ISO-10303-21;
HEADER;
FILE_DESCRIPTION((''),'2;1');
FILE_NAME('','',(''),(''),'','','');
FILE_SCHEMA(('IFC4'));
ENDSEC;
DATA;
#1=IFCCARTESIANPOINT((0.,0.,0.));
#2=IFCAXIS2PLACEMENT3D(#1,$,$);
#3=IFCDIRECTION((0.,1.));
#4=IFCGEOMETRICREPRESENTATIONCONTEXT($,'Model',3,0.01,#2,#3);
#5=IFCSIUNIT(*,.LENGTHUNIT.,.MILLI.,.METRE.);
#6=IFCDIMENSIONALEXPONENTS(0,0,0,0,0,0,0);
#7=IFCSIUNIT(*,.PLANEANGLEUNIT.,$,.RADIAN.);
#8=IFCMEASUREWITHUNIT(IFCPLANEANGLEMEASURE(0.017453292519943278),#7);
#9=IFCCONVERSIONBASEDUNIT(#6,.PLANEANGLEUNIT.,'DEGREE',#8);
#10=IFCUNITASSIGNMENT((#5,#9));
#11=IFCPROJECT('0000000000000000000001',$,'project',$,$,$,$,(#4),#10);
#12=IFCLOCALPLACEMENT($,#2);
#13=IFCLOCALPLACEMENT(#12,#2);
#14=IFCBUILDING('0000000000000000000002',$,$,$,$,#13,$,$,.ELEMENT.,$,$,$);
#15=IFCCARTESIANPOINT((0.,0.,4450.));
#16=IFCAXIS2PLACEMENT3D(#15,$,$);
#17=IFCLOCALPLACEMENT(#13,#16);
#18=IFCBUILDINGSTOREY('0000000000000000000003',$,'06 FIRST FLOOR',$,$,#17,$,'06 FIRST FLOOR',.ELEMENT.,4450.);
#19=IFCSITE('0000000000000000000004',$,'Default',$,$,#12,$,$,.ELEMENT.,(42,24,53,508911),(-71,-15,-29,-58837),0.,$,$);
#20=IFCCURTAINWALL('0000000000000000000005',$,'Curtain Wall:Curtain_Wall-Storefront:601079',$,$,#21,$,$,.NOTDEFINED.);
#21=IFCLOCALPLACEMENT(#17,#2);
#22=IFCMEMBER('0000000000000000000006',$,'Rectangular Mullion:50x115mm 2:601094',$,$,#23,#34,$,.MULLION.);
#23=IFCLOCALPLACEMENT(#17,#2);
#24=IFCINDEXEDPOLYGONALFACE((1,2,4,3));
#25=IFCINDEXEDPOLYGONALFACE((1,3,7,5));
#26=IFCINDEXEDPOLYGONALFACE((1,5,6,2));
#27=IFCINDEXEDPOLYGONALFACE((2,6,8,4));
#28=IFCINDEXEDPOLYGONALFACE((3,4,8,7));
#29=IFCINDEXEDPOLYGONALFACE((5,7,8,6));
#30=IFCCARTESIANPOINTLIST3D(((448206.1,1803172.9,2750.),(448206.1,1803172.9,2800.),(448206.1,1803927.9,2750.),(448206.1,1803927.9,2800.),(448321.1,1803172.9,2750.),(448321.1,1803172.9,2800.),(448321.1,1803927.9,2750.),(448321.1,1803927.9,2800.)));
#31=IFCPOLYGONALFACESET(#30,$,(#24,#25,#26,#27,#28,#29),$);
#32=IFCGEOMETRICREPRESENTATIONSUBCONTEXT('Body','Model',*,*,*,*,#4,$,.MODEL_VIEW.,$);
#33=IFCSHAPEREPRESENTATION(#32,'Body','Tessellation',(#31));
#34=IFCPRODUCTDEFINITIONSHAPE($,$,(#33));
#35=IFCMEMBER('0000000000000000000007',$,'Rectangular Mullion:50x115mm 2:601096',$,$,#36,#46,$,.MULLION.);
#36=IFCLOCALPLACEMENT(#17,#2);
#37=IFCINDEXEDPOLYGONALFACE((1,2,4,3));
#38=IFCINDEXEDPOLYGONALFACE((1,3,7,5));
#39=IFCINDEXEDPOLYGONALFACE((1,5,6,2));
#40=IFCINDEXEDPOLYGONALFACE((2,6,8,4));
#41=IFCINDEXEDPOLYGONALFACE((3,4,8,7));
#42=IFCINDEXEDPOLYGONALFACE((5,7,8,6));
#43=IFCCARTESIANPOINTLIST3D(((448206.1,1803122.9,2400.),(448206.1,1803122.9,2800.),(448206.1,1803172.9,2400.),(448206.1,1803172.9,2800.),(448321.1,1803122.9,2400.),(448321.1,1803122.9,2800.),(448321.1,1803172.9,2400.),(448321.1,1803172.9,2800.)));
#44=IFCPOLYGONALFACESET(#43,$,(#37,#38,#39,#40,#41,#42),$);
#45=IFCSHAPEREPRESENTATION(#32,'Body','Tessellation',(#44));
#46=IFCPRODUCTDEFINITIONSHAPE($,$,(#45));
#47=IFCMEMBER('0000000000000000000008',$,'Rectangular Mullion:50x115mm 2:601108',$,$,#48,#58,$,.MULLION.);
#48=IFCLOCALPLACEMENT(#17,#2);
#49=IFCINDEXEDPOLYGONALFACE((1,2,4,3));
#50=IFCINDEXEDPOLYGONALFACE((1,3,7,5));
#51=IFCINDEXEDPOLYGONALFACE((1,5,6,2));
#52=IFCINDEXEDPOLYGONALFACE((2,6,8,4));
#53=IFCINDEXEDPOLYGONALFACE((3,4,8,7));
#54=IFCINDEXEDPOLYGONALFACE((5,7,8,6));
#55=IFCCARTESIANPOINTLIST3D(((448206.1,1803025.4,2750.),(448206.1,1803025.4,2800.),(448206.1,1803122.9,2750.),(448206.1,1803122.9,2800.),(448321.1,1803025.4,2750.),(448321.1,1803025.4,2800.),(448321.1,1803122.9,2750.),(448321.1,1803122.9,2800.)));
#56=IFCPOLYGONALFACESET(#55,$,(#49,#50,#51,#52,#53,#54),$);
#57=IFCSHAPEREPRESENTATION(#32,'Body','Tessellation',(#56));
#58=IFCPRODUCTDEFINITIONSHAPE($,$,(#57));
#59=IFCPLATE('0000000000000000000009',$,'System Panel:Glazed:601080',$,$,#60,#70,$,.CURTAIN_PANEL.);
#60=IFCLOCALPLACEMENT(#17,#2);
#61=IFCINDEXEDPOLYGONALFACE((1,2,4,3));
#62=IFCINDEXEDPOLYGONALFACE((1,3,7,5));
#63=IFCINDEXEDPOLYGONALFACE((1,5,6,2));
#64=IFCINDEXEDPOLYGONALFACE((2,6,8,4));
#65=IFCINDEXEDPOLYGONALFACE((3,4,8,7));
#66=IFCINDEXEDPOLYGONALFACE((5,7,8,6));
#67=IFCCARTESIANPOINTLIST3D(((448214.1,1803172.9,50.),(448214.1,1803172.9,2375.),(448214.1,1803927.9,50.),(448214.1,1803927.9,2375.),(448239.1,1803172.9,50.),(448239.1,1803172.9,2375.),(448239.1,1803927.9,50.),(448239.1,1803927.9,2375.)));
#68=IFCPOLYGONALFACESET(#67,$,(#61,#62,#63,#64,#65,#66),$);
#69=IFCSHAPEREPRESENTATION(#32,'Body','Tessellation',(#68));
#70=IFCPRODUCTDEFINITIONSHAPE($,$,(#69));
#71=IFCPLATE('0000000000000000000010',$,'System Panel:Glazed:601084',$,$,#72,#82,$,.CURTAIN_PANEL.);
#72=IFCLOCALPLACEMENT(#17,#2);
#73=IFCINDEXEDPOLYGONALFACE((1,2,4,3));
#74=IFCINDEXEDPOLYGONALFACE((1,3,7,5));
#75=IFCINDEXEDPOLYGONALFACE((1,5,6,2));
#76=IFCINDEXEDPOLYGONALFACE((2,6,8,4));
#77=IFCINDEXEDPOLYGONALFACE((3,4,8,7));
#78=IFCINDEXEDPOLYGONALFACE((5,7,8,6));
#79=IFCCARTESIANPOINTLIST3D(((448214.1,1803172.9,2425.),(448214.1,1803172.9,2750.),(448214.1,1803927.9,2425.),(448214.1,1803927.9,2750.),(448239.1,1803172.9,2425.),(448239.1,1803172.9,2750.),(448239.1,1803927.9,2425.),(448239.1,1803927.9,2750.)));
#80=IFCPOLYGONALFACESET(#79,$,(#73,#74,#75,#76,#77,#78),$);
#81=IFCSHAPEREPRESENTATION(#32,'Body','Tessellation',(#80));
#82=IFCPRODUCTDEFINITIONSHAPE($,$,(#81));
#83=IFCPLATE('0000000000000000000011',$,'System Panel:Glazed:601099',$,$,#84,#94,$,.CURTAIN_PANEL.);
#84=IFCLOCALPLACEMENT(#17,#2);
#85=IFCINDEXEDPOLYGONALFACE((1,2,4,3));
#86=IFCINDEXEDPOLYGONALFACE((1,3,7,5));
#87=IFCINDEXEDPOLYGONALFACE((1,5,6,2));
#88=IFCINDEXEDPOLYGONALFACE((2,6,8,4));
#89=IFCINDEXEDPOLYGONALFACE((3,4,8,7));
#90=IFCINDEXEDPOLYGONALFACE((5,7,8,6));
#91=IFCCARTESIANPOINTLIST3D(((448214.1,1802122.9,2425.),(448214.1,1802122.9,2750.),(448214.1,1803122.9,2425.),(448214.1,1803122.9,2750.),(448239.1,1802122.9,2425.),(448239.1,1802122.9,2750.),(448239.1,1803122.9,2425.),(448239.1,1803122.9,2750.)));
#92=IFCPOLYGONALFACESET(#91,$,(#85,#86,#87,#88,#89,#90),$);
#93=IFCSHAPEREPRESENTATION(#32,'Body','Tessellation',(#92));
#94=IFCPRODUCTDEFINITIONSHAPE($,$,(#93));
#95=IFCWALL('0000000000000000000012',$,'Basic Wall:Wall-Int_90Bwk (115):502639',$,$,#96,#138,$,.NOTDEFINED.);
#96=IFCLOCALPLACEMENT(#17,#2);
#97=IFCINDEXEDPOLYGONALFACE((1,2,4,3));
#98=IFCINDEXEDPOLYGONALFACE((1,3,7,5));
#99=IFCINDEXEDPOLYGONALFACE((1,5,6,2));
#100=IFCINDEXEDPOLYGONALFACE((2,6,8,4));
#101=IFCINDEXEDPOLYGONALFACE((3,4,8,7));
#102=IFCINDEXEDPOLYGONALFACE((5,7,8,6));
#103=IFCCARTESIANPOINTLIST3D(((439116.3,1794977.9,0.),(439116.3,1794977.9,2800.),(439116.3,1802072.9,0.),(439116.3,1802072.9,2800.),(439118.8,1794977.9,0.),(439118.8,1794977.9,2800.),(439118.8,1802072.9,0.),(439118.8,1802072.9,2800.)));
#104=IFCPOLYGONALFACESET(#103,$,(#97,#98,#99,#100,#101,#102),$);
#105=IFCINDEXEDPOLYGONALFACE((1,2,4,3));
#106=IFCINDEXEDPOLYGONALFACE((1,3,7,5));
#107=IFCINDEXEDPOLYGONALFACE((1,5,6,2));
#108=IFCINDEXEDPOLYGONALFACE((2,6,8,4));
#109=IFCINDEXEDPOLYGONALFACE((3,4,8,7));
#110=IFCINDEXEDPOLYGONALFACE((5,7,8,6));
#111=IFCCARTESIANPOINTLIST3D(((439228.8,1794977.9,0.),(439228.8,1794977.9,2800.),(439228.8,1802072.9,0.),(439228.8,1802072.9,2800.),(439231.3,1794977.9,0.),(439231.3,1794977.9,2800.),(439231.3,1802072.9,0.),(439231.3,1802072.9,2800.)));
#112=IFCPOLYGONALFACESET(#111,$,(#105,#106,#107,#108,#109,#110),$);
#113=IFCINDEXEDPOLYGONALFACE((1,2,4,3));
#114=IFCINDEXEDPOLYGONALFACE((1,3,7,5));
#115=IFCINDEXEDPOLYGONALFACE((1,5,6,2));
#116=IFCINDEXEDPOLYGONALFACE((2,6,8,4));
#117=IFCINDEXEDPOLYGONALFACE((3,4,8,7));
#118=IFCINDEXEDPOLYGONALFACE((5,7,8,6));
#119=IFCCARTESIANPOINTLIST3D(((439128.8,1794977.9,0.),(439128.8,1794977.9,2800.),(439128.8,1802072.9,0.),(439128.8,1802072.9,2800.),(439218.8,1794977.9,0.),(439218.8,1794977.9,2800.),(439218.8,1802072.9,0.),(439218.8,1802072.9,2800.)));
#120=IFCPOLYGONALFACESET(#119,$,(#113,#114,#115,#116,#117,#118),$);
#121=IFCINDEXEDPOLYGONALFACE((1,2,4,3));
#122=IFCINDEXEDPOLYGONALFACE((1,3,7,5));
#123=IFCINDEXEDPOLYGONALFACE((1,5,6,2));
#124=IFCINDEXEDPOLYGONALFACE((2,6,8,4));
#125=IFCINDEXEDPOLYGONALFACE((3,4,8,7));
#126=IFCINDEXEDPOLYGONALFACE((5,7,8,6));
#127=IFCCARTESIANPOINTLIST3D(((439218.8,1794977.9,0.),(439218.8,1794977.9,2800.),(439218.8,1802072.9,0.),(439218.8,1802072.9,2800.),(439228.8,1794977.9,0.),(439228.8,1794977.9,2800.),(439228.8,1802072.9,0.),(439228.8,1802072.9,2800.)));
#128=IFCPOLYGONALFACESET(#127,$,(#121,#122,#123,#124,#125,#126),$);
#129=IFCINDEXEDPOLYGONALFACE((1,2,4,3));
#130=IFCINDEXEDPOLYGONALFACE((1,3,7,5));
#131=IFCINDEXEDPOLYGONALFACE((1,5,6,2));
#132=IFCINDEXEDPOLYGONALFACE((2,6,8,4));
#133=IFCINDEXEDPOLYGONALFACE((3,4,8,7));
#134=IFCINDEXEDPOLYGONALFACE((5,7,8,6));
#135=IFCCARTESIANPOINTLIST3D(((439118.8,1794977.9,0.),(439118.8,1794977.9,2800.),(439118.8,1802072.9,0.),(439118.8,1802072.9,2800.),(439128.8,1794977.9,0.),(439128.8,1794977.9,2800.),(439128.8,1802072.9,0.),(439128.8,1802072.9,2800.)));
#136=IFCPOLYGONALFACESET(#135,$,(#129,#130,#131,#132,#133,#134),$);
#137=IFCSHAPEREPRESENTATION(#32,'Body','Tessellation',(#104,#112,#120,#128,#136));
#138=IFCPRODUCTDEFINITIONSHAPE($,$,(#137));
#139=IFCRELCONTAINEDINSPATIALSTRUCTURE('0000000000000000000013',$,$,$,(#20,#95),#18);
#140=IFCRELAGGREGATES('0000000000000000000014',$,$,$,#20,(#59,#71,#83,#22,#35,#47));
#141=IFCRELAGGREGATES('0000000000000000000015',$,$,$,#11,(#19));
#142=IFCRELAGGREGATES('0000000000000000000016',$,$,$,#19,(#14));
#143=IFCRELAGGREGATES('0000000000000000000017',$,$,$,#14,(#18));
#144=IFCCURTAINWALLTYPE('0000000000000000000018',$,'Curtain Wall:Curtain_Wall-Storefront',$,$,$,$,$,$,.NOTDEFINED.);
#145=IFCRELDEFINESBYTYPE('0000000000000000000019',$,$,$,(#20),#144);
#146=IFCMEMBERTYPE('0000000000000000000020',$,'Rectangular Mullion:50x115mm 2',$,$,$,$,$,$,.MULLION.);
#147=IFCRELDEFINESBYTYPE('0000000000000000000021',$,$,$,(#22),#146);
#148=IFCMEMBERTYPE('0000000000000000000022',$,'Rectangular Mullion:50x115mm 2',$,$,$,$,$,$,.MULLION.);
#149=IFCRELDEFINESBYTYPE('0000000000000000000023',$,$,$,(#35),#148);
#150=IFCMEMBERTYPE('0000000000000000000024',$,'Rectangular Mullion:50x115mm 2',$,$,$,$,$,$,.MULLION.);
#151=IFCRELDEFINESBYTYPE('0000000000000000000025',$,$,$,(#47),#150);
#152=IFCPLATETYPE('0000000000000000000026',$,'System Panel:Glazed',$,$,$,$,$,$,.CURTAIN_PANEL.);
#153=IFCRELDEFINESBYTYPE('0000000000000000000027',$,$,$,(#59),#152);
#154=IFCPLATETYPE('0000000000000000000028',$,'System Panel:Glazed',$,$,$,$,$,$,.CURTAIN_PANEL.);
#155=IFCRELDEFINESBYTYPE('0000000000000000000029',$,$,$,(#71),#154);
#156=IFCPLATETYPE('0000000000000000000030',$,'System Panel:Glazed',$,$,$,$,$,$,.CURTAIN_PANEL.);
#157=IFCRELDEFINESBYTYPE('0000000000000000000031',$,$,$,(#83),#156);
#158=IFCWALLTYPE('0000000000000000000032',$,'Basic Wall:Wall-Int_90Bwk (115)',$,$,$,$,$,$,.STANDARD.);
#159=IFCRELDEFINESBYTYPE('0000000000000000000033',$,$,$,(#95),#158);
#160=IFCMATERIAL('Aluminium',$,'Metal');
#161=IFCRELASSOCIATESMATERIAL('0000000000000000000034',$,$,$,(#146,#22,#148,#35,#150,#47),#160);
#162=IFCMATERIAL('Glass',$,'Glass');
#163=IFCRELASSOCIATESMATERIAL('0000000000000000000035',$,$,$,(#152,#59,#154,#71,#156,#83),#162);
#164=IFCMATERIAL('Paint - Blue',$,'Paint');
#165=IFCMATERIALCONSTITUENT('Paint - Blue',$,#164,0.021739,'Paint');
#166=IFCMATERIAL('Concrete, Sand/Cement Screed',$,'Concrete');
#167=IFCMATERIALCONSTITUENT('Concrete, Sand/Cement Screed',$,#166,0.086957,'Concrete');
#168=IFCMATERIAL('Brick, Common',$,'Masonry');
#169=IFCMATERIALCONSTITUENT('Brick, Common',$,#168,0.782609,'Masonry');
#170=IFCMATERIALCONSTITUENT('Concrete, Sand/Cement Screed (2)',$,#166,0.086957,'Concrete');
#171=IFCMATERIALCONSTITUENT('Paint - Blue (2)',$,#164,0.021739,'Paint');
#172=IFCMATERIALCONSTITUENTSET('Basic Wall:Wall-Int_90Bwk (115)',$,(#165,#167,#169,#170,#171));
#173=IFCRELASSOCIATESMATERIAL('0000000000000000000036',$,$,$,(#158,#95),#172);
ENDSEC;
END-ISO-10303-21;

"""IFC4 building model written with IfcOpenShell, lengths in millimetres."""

from ifc_helpers import new_model, entity, si_unit, converted_unit, direction, frame, origin, place, context, subcontext, project, spatial, indexed_curve, outline, extrude, source, transform, mapped, material, constituent, constituent_set, type_object, type_shapes, element, aggregate, save


model = new_model("IFC4")

# Units and contexts
model_context = context("Model", 3, precision=0.01, world=origin(), true_north=direction((0.0, 1.0)))
body_context = subcontext(model_context, "Body", "Model", "MODEL_VIEW")
ifc_project = project(units=[si_unit("LENGTHUNIT", "METRE", prefix="MILLI"), converted_unit("PLANEANGLEUNIT", "DEGREE", entity("IfcPlaneAngleMeasure", 0.017453292519943278), si_unit("PLANEANGLEUNIT", "RADIAN"), dimensions=[0, 0, 0, 0, 0, 0, 0])], contexts=[model_context])

# Site, building, storey
site_placement = place(None, origin())
site = spatial("IfcSite", under=ifc_project, at=site_placement, Name="Default", CompositionType="ELEMENT", RefLatitude=(42, 24, 53, 508911), RefLongitude=(-71, -15, -29, -58837), RefElevation=0.0)
building_placement = place(site_placement, origin())
building = spatial("IfcBuilding", under=site, at=building_placement, CompositionType="ELEMENT")
storey_placement = place(building_placement, frame((0.0, 0.0, 4450.0)))
storey = spatial("IfcBuildingStorey", under=building, at=storey_placement, Name="06 FIRST FLOOR", LongName="06 FIRST FLOOR", CompositionType="ELEMENT", Elevation=4450.0)

# Curtain wall
curtain_wall_type = type_object("IfcCurtainWallType", Name="Curtain Wall:Curtain_Wall-Storefront", PredefinedType="NOTDEFINED")
ifc_material_1 = material(Name="Aluminium", Category="Metal")
curtain_wall_1_placement = place(storey_placement, frame((0.0, 0.0, -4450.0)))
curtain_wall_1 = element("IfcCurtainWall", 1, at=curtain_wall_1_placement, inside=storey, type_object=curtain_wall_type, Name="Curtain Wall:Curtain_Wall-Storefront:601079", PredefinedType="NOTDEFINED")

# Members
member_type_1 = type_object("IfcMemberType", Name="Rectangular Mullion:50x115mm 2", PredefinedType="MULLION", material=ifc_material_1)
shared_shape_1 = source(origin(), body_context, "Body", "SweptSolid", [
    extrude(outline(indexed_curve([(-25.0, -57.5), (25.0, -57.5), (25.0, 57.5), (-25.0, 57.5), (-25.0, -57.5)], self_intersect=False)), frame((-25.0, 0.0, -755.0), z_axis=(0.0, 0.0, 1.0), x_axis=(-1.0, 0.0, 0.0)), (0.0, 0.0, 1.0), 755.0),
])
type_shapes(member_type_1, [shared_shape_1])
member_1_placement = place(curtain_wall_1_placement, frame((448263.6, 1803172.9, 7250.0), z_axis=(0.0, -1.0, 0.0), x_axis=(0.0, 0.0, 1.0)))
member_1 = element("IfcMember", 2, at=member_1_placement, type_object=member_type_1, material=ifc_material_1, Name="Rectangular Mullion:50x115mm 2:601094", PredefinedType="MULLION", context=body_context, shape_type="MappedRepresentation", body=[
    mapped(shared_shape_1, transform((0.0, 0.0, 0.0), scale=1.0)),
])
member_type_2 = type_object("IfcMemberType", Name="Rectangular Mullion:50x115mm 2", PredefinedType="MULLION", material=ifc_material_1)
shared_shape_2 = source(origin(), body_context, "Body", "SweptSolid", [
    extrude(outline(indexed_curve([(-25.0, -57.5), (25.0, -57.5), (25.0, 57.5), (-25.0, 57.5), (-25.0, -57.5)], self_intersect=False)), frame((0.0, 0.0, -400.0), z_axis=(0.0, 0.0, 1.0), x_axis=(-1.0, 0.0, 0.0)), (0.0, 0.0, 1.0), 400.0),
])
type_shapes(member_type_2, [shared_shape_2])
member_2_placement = place(curtain_wall_1_placement, frame((448263.6, 1803147.9, 6850.0), z_axis=(0.0, 0.0, -1.0), x_axis=(0.0, -1.0, 0.0)))
member_2 = element("IfcMember", 3, at=member_2_placement, type_object=member_type_2, material=ifc_material_1, Name="Rectangular Mullion:50x115mm 2:601096", PredefinedType="MULLION", context=body_context, shape_type="MappedRepresentation", body=[
    mapped(shared_shape_2, transform((0.0, 0.0, 0.0), scale=1.0)),
])
member_type_3 = type_object("IfcMemberType", Name="Rectangular Mullion:50x115mm 2", PredefinedType="MULLION", material=ifc_material_1)
shared_shape_3 = source(origin(), body_context, "Body", "SweptSolid", [
    extrude(outline(indexed_curve([(-25.0, -57.5), (25.0, -57.5), (25.0, 57.5), (-25.0, 57.5), (-25.0, -57.5)], self_intersect=False)), frame((-25.0, 0.0, -97.5), z_axis=(0.0, 0.0, 1.0), x_axis=(-1.0, 0.0, 0.0)), (0.0, 0.0, 1.0), 97.5),
])
type_shapes(member_type_3, [shared_shape_3])
member_3_placement = place(curtain_wall_1_placement, frame((448263.6, 1803025.4, 7250.0), z_axis=(0.0, -1.0, 0.0), x_axis=(0.0, 0.0, 1.0)))
member_3 = element("IfcMember", 4, at=member_3_placement, type_object=member_type_3, material=ifc_material_1, Name="Rectangular Mullion:50x115mm 2:601108", PredefinedType="MULLION", context=body_context, shape_type="MappedRepresentation", body=[
    mapped(shared_shape_3, transform((0.0, 0.0, 0.0), scale=1.0)),
])

# Plates
ifc_material_2 = material(Name="Glass", Category="Glass")
plate_type_1 = type_object("IfcPlateType", Name="System Panel:Glazed", PredefinedType="CURTAIN_PANEL", material=ifc_material_2)
shared_shape_4 = source(origin(), body_context, "Body", "SweptSolid", [
    extrude(outline(indexed_curve([(-12.5, -377.5), (12.5, -377.5), (12.5, 377.5), (-12.5, 377.5), (-12.5, -377.5)], self_intersect=False)), frame((0.0, -37.0, 0.0), z_axis=(0.0, 0.0, 1.0), x_axis=(0.0, 1.0, 0.0)), (0.0, 0.0, 1.0), 2325.0),
])
type_shapes(plate_type_1, [shared_shape_4])
plate_1_placement = place(curtain_wall_1_placement, frame((448263.6, 1803550.4, 4500.0), z_axis=(0.0, 0.0, 1.0), x_axis=(0.0, -1.0, 0.0)))
plate_1 = element("IfcPlate", 5, at=plate_1_placement, type_object=plate_type_1, material=ifc_material_2, Name="System Panel:Glazed:601080", PredefinedType="CURTAIN_PANEL", context=body_context, shape_type="MappedRepresentation", body=[
    mapped(shared_shape_4, transform((0.0, 0.0, 0.0), scale=1.0)),
])
plate_type_2 = type_object("IfcPlateType", Name="System Panel:Glazed", PredefinedType="CURTAIN_PANEL", material=ifc_material_2)
shared_shape_5 = source(origin(), body_context, "Body", "SweptSolid", [
    extrude(outline(indexed_curve([(-12.5, -377.5), (12.5, -377.5), (12.5, 377.5), (-12.5, 377.5), (-12.5, -377.5)], self_intersect=False)), frame((0.0, -37.0, 0.0), z_axis=(0.0, 0.0, 1.0), x_axis=(0.0, 1.0, 0.0)), (0.0, 0.0, 1.0), 325.0),
])
type_shapes(plate_type_2, [shared_shape_5])
plate_2_placement = place(curtain_wall_1_placement, frame((448263.6, 1803550.4, 6875.0), z_axis=(0.0, 0.0, 1.0), x_axis=(0.0, -1.0, 0.0)))
plate_2 = element("IfcPlate", 6, at=plate_2_placement, type_object=plate_type_2, material=ifc_material_2, Name="System Panel:Glazed:601084", PredefinedType="CURTAIN_PANEL", context=body_context, shape_type="MappedRepresentation", body=[
    mapped(shared_shape_5, transform((0.0, 0.0, 0.0), scale=1.0)),
])
plate_type_3 = type_object("IfcPlateType", Name="System Panel:Glazed", PredefinedType="CURTAIN_PANEL", material=ifc_material_2)
shared_shape_6 = source(origin(), body_context, "Body", "SweptSolid", [
    extrude(outline(indexed_curve([(-12.5, -500.0), (12.5, -500.0), (12.5, 500.0), (-12.5, 500.0), (-12.5, -500.0)], self_intersect=False)), frame((0.0, -37.0, 0.0), z_axis=(0.0, 0.0, 1.0), x_axis=(0.0, 1.0, 0.0)), (0.0, 0.0, 1.0), 325.0),
])
type_shapes(plate_type_3, [shared_shape_6])
plate_3_placement = place(curtain_wall_1_placement, frame((448263.6, 1802622.9, 6875.0), z_axis=(0.0, 0.0, 1.0), x_axis=(0.0, -1.0, 0.0)))
plate_3 = element("IfcPlate", 7, at=plate_3_placement, type_object=plate_type_3, material=ifc_material_2, Name="System Panel:Glazed:601099", PredefinedType="CURTAIN_PANEL", context=body_context, shape_type="MappedRepresentation", body=[
    mapped(shared_shape_6, transform((0.0, 0.0, 0.0), scale=1.0)),
])

# Wall
ifc_material_3 = material(Name="Paint - Blue", Category="Paint")
ifc_constituent_1 = constituent(ifc_material_3, Name="Paint - Blue", Category="Paint", fraction=0.021739)
ifc_material_4 = material(Name="Concrete, Sand/Cement Screed", Category="Concrete")
ifc_constituent_2 = constituent(ifc_material_4, Name="Concrete, Sand/Cement Screed", Category="Concrete", fraction=0.086957)
ifc_material_5 = material(Name="Brick, Common", Category="Masonry")
ifc_constituent_3 = constituent(ifc_material_5, Name="Brick, Common", Category="Masonry", fraction=0.782609)
ifc_constituent_4 = constituent(ifc_material_4, Name="Concrete, Sand/Cement Screed (2)", Category="Concrete", fraction=0.086957)
ifc_constituent_5 = constituent(ifc_material_3, Name="Paint - Blue (2)", Category="Paint", fraction=0.021739)
ifc_constituent_set_1 = constituent_set(constituents=[ifc_constituent_1, ifc_constituent_2, ifc_constituent_3, ifc_constituent_4, ifc_constituent_5], Name="Basic Wall:Wall-Int_90Bwk (115)")
wall_type = type_object("IfcWallType", Name="Basic Wall:Wall-Int_90Bwk (115)", PredefinedType="STANDARD", material=ifc_constituent_set_1)
wall_1_placement = place(storey_placement, frame((439173.8, 1802072.9, 0.0), z_axis=(0.0, 0.0, 1.0), x_axis=(0.0, -1.0, 0.0)))
element("IfcWall", 8, at=wall_1_placement, inside=storey, type_object=wall_type, material=ifc_constituent_set_1, Name="Basic Wall:Wall-Int_90Bwk (115):502639", PredefinedType="NOTDEFINED", context=body_context, shape_type="SweptSolid", body=[
    extrude(outline(indexed_curve([(-1.3, -3547.5), (1.2, -3547.5), (1.2, 3547.5), (-1.3, 3547.5), (-1.3, -3547.5)], self_intersect=False)), frame((3547.5, -56.2, 0.0), z_axis=(0.0, 0.0, 1.0), x_axis=(0.0, 1.0, 0.0)), (0.0, 0.0, 1.0), 2800.0),
    extrude(outline(indexed_curve([(-1.3, -3547.5), (1.2, -3547.5), (1.2, 3547.5), (-1.3, 3547.5), (-1.3, -3547.5)], self_intersect=False)), frame((3547.5, 56.2, 0.0), z_axis=(0.0, 0.0, 1.0), x_axis=(0.0, -1.0, 0.0)), (0.0, 0.0, 1.0), 2800.0),
    extrude(outline(indexed_curve([(-3547.5, -45.0), (3547.5, -45.0), (3547.5, 45.0), (-3547.5, 45.0), (-3547.5, -45.0)], self_intersect=False)), frame((3547.5, 0.0, 0.0)), (0.0, 0.0, 1.0), 2800.0),
    extrude(outline(indexed_curve([(-3547.5, -5.0), (3547.5, -5.0), (3547.5, 5.0), (-3547.5, 5.0), (-3547.5, -5.0)], self_intersect=False)), frame((3547.5, 50.0, 0.0)), (0.0, 0.0, 1.0), 2800.0),
    extrude(outline(indexed_curve([(-3547.5, -5.0), (3547.5, -5.0), (3547.5, 5.0), (-3547.5, 5.0), (-3547.5, -5.0)], self_intersect=False)), frame((3547.5, -50.0, 0.0)), (0.0, 0.0, 1.0), 2800.0),
])

aggregate(curtain_wall_1, [plate_1, plate_2, plate_3, member_1, member_2, member_3])

save(model, "model.ifc")
